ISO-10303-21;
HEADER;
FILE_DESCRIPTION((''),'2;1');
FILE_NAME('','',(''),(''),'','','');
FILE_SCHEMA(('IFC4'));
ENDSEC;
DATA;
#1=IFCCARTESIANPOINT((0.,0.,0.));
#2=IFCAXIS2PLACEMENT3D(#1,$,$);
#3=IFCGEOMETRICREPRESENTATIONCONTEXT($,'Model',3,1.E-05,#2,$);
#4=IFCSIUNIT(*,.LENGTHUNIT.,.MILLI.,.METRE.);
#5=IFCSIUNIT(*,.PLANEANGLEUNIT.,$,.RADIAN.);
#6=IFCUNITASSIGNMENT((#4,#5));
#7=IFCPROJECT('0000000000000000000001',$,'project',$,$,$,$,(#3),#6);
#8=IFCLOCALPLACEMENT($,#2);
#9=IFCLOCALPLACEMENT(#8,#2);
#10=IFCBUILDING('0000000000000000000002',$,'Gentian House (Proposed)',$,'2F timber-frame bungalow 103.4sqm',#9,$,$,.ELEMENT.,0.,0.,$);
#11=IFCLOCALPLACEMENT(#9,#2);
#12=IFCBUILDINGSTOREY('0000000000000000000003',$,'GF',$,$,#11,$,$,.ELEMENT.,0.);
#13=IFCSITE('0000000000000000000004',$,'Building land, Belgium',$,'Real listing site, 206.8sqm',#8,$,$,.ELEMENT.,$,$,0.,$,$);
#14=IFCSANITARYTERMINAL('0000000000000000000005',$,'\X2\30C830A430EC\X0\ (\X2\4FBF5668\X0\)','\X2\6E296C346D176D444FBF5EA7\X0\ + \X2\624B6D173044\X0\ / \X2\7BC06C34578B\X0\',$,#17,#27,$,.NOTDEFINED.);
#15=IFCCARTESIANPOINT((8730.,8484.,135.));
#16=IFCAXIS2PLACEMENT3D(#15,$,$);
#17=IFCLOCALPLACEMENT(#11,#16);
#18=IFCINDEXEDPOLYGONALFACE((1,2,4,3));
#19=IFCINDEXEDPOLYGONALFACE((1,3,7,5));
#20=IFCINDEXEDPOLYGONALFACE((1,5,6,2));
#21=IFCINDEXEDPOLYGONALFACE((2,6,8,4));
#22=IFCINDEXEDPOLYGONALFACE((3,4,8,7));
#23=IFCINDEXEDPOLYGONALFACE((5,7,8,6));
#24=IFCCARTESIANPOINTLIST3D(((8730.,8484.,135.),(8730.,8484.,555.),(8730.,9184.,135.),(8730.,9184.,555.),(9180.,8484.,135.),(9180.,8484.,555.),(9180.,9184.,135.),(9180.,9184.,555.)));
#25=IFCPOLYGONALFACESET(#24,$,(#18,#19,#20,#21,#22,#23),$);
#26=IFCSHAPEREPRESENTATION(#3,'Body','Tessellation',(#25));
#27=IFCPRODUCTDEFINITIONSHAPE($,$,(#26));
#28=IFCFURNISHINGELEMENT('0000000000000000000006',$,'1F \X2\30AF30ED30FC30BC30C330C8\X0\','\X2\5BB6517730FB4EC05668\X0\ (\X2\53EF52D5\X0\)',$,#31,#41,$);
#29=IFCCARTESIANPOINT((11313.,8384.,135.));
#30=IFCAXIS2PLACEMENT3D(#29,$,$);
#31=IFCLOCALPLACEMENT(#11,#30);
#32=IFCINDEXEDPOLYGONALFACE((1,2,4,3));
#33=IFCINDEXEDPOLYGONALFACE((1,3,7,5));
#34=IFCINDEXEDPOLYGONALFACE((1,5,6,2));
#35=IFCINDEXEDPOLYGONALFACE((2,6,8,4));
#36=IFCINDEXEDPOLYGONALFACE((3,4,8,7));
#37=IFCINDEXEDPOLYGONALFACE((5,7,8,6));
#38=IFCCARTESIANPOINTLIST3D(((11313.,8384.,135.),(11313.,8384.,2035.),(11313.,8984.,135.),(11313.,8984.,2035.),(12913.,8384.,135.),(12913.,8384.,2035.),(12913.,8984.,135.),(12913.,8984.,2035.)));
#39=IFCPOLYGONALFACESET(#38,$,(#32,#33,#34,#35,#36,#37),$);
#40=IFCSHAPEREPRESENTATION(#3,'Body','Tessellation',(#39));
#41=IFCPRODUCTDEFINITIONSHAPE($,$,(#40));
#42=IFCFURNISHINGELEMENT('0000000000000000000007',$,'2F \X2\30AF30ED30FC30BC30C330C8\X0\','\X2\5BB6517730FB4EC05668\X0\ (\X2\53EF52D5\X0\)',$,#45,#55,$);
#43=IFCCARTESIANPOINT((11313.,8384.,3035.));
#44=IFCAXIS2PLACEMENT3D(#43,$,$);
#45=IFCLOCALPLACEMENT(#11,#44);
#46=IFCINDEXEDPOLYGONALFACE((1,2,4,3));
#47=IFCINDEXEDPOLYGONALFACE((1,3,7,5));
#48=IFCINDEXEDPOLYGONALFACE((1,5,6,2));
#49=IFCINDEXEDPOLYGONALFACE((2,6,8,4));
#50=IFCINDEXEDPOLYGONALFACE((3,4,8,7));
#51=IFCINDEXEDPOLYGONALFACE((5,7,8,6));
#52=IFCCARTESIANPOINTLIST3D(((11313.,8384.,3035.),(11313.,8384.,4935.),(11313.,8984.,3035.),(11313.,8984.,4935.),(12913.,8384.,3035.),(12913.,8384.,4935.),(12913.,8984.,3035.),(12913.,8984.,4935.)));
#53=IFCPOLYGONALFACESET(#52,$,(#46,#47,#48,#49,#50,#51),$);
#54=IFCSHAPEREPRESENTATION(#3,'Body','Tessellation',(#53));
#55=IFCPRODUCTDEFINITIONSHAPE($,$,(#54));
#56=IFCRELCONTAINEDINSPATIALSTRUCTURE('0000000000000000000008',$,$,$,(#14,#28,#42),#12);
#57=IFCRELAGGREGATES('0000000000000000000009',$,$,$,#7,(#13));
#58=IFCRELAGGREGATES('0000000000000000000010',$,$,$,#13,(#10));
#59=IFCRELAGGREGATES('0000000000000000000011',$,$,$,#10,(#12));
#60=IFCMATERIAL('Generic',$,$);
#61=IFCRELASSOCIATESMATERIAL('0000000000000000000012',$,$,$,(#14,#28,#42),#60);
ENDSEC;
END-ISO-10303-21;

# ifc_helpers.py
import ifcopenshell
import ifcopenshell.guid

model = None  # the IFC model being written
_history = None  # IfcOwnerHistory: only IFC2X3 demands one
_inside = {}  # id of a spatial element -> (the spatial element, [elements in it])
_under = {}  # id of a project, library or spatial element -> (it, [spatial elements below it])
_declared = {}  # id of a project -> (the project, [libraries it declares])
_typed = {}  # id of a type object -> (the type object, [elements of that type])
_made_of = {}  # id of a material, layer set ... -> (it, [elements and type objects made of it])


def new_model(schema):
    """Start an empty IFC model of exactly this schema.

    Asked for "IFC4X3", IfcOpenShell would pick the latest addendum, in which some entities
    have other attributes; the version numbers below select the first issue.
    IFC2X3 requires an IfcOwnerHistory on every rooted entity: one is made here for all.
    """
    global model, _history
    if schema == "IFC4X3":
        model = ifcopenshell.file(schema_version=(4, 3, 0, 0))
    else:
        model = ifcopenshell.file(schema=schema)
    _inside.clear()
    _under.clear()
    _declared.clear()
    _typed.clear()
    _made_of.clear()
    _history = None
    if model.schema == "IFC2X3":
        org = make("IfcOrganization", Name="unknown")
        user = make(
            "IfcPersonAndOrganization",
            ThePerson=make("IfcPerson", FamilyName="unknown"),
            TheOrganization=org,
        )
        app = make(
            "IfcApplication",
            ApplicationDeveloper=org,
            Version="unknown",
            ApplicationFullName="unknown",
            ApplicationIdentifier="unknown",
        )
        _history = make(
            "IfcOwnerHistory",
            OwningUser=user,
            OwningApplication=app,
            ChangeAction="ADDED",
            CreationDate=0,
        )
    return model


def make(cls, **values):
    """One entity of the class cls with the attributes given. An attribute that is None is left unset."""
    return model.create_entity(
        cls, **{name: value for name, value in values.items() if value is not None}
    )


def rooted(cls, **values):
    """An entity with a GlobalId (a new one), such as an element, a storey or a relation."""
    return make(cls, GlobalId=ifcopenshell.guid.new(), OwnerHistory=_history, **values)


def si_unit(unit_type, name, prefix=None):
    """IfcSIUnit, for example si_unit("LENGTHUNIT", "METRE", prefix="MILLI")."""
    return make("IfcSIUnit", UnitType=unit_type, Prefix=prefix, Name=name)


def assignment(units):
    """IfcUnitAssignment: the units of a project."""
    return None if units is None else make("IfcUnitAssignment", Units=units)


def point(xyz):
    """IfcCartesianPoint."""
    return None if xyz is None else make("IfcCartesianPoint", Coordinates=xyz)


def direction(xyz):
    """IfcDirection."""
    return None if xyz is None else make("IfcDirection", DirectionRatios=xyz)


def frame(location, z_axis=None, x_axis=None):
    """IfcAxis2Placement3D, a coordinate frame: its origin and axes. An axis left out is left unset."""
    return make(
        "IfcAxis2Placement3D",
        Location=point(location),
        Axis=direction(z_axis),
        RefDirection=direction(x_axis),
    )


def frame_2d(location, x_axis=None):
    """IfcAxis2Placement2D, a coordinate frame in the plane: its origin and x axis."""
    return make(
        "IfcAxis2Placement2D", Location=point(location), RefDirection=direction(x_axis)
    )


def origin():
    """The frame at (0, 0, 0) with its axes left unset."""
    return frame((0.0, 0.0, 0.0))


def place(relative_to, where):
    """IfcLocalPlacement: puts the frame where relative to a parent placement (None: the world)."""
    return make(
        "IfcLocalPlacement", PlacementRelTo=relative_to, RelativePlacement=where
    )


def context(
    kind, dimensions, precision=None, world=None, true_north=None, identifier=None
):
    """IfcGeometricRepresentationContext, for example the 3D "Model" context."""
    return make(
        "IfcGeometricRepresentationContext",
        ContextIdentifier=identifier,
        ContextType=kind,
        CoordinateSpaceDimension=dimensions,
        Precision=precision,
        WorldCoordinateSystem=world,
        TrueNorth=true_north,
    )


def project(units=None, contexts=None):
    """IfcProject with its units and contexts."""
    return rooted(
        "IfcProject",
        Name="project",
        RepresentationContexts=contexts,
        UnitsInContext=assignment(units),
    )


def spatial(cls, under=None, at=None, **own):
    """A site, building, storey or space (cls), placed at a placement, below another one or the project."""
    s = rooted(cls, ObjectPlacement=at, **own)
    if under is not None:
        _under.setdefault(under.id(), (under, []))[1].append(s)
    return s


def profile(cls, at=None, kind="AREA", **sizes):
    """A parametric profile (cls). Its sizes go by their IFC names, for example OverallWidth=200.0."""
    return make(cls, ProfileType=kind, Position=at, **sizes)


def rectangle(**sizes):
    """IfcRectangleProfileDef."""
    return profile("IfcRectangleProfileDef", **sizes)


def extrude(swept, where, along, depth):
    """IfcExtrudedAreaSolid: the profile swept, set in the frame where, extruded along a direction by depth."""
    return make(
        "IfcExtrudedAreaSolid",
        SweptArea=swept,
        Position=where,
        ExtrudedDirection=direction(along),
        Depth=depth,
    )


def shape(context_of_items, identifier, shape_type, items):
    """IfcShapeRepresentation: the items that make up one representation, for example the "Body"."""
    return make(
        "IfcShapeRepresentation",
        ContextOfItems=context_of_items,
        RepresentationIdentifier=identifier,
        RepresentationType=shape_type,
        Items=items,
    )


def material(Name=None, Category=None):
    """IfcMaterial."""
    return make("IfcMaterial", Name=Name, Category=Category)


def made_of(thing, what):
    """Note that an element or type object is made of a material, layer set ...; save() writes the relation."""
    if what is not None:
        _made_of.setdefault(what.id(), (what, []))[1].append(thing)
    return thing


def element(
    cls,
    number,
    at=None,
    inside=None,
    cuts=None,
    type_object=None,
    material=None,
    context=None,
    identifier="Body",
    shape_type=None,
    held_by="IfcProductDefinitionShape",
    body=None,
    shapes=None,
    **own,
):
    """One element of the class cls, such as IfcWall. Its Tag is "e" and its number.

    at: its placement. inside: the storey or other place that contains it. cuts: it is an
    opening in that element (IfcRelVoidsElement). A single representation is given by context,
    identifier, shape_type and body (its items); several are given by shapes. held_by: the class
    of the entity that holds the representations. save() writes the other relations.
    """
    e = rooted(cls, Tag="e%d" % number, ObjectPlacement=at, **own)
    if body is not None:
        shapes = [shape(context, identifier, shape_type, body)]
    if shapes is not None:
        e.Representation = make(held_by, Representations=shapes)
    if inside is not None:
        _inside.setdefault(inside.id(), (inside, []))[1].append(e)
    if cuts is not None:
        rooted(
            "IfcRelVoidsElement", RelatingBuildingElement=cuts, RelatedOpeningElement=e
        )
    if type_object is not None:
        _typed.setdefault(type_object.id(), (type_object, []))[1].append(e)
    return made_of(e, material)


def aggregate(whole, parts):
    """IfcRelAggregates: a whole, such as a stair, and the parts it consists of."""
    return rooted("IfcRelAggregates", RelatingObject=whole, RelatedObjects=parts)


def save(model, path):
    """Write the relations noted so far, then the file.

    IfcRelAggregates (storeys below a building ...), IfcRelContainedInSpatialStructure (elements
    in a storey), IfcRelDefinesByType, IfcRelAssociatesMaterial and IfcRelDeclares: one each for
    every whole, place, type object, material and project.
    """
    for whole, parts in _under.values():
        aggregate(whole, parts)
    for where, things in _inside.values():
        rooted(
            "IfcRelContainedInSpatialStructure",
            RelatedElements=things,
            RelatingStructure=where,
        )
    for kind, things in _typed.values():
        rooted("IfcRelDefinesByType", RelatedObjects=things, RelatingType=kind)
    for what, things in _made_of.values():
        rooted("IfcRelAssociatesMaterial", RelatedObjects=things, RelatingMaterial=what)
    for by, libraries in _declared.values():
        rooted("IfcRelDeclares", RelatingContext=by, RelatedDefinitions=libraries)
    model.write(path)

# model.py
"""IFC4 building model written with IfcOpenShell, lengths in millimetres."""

from ifc_helpers import new_model, si_unit, frame, frame_2d, origin, place, context, project, spatial, rectangle, extrude, material, element, save


model = new_model("IFC4")

# Units and contexts
model_context = context("Model", 3, precision=1e-05, world=origin())
ifc_project = project(units=[si_unit("LENGTHUNIT", "METRE", prefix="MILLI"), si_unit("PLANEANGLEUNIT", "RADIAN")], contexts=[model_context])

# Site, building, storey
site_placement = place(None, origin())
site = spatial("IfcSite", under=ifc_project, at=site_placement, Name="Building land, Belgium", ObjectType="Real listing site, 206.8sqm", CompositionType="ELEMENT", RefElevation=0.0)
building_placement = place(site_placement, origin())
building = spatial("IfcBuilding", under=site, at=building_placement, Name="Gentian House (Proposed)", ObjectType="2F timber-frame bungalow 103.4sqm", CompositionType="ELEMENT", ElevationOfRefHeight=0.0, ElevationOfTerrain=0.0)
storey_placement = place(building_placement, origin())
storey = spatial("IfcBuildingStorey", under=building, at=storey_placement, Name="GF", CompositionType="ELEMENT", Elevation=0.0)

# Shared definitions
ifc_material_1 = material(Name="Generic")

# Sanitary terminal
sanitary_terminal_1_placement = place(storey_placement, frame((8730.0, 8484.0, 135.0)))
element("IfcSanitaryTerminal", 1, at=sanitary_terminal_1_placement, inside=storey, material=ifc_material_1, Name="トイレ (便器)", Description="温水洗浄便座 + 手洗い / 節水型", PredefinedType="NOTDEFINED", context=model_context, shape_type="SweptSolid", body=[
    extrude(rectangle(XDim=450.0, YDim=700.0, at=frame_2d((225.0, 350.0))), frame((8730.0, 8484.0, 135.0)), (0.0, 0.0, 1.0), 420.0),
])

# Furnishing elements
furnishing_1_placement = place(storey_placement, frame((11313.0, 8384.0, 135.0)))
element("IfcFurnishingElement", 2, at=furnishing_1_placement, inside=storey, material=ifc_material_1, Name="1F クローゼット", Description="家具・什器 (可動)", context=model_context, shape_type="SweptSolid", body=[
    extrude(rectangle(XDim=1600.0, YDim=600.0, at=frame_2d((800.0, 300.0))), frame((11313.0, 8384.0, 135.0)), (0.0, 0.0, 1.0), 1900.0),
])
furnishing_2_placement = place(storey_placement, frame((11313.0, 8384.0, 3035.0)))
element("IfcFurnishingElement", 3, at=furnishing_2_placement, inside=storey, material=ifc_material_1, Name="2F クローゼット", Description="家具・什器 (可動)", context=model_context, shape_type="SweptSolid", body=[
    extrude(rectangle(XDim=1600.0, YDim=600.0, at=frame_2d((800.0, 300.0))), frame((11313.0, 8384.0, 3035.0)), (0.0, 0.0, 1.0), 1900.0),
])

save(model, "model.ifc")
